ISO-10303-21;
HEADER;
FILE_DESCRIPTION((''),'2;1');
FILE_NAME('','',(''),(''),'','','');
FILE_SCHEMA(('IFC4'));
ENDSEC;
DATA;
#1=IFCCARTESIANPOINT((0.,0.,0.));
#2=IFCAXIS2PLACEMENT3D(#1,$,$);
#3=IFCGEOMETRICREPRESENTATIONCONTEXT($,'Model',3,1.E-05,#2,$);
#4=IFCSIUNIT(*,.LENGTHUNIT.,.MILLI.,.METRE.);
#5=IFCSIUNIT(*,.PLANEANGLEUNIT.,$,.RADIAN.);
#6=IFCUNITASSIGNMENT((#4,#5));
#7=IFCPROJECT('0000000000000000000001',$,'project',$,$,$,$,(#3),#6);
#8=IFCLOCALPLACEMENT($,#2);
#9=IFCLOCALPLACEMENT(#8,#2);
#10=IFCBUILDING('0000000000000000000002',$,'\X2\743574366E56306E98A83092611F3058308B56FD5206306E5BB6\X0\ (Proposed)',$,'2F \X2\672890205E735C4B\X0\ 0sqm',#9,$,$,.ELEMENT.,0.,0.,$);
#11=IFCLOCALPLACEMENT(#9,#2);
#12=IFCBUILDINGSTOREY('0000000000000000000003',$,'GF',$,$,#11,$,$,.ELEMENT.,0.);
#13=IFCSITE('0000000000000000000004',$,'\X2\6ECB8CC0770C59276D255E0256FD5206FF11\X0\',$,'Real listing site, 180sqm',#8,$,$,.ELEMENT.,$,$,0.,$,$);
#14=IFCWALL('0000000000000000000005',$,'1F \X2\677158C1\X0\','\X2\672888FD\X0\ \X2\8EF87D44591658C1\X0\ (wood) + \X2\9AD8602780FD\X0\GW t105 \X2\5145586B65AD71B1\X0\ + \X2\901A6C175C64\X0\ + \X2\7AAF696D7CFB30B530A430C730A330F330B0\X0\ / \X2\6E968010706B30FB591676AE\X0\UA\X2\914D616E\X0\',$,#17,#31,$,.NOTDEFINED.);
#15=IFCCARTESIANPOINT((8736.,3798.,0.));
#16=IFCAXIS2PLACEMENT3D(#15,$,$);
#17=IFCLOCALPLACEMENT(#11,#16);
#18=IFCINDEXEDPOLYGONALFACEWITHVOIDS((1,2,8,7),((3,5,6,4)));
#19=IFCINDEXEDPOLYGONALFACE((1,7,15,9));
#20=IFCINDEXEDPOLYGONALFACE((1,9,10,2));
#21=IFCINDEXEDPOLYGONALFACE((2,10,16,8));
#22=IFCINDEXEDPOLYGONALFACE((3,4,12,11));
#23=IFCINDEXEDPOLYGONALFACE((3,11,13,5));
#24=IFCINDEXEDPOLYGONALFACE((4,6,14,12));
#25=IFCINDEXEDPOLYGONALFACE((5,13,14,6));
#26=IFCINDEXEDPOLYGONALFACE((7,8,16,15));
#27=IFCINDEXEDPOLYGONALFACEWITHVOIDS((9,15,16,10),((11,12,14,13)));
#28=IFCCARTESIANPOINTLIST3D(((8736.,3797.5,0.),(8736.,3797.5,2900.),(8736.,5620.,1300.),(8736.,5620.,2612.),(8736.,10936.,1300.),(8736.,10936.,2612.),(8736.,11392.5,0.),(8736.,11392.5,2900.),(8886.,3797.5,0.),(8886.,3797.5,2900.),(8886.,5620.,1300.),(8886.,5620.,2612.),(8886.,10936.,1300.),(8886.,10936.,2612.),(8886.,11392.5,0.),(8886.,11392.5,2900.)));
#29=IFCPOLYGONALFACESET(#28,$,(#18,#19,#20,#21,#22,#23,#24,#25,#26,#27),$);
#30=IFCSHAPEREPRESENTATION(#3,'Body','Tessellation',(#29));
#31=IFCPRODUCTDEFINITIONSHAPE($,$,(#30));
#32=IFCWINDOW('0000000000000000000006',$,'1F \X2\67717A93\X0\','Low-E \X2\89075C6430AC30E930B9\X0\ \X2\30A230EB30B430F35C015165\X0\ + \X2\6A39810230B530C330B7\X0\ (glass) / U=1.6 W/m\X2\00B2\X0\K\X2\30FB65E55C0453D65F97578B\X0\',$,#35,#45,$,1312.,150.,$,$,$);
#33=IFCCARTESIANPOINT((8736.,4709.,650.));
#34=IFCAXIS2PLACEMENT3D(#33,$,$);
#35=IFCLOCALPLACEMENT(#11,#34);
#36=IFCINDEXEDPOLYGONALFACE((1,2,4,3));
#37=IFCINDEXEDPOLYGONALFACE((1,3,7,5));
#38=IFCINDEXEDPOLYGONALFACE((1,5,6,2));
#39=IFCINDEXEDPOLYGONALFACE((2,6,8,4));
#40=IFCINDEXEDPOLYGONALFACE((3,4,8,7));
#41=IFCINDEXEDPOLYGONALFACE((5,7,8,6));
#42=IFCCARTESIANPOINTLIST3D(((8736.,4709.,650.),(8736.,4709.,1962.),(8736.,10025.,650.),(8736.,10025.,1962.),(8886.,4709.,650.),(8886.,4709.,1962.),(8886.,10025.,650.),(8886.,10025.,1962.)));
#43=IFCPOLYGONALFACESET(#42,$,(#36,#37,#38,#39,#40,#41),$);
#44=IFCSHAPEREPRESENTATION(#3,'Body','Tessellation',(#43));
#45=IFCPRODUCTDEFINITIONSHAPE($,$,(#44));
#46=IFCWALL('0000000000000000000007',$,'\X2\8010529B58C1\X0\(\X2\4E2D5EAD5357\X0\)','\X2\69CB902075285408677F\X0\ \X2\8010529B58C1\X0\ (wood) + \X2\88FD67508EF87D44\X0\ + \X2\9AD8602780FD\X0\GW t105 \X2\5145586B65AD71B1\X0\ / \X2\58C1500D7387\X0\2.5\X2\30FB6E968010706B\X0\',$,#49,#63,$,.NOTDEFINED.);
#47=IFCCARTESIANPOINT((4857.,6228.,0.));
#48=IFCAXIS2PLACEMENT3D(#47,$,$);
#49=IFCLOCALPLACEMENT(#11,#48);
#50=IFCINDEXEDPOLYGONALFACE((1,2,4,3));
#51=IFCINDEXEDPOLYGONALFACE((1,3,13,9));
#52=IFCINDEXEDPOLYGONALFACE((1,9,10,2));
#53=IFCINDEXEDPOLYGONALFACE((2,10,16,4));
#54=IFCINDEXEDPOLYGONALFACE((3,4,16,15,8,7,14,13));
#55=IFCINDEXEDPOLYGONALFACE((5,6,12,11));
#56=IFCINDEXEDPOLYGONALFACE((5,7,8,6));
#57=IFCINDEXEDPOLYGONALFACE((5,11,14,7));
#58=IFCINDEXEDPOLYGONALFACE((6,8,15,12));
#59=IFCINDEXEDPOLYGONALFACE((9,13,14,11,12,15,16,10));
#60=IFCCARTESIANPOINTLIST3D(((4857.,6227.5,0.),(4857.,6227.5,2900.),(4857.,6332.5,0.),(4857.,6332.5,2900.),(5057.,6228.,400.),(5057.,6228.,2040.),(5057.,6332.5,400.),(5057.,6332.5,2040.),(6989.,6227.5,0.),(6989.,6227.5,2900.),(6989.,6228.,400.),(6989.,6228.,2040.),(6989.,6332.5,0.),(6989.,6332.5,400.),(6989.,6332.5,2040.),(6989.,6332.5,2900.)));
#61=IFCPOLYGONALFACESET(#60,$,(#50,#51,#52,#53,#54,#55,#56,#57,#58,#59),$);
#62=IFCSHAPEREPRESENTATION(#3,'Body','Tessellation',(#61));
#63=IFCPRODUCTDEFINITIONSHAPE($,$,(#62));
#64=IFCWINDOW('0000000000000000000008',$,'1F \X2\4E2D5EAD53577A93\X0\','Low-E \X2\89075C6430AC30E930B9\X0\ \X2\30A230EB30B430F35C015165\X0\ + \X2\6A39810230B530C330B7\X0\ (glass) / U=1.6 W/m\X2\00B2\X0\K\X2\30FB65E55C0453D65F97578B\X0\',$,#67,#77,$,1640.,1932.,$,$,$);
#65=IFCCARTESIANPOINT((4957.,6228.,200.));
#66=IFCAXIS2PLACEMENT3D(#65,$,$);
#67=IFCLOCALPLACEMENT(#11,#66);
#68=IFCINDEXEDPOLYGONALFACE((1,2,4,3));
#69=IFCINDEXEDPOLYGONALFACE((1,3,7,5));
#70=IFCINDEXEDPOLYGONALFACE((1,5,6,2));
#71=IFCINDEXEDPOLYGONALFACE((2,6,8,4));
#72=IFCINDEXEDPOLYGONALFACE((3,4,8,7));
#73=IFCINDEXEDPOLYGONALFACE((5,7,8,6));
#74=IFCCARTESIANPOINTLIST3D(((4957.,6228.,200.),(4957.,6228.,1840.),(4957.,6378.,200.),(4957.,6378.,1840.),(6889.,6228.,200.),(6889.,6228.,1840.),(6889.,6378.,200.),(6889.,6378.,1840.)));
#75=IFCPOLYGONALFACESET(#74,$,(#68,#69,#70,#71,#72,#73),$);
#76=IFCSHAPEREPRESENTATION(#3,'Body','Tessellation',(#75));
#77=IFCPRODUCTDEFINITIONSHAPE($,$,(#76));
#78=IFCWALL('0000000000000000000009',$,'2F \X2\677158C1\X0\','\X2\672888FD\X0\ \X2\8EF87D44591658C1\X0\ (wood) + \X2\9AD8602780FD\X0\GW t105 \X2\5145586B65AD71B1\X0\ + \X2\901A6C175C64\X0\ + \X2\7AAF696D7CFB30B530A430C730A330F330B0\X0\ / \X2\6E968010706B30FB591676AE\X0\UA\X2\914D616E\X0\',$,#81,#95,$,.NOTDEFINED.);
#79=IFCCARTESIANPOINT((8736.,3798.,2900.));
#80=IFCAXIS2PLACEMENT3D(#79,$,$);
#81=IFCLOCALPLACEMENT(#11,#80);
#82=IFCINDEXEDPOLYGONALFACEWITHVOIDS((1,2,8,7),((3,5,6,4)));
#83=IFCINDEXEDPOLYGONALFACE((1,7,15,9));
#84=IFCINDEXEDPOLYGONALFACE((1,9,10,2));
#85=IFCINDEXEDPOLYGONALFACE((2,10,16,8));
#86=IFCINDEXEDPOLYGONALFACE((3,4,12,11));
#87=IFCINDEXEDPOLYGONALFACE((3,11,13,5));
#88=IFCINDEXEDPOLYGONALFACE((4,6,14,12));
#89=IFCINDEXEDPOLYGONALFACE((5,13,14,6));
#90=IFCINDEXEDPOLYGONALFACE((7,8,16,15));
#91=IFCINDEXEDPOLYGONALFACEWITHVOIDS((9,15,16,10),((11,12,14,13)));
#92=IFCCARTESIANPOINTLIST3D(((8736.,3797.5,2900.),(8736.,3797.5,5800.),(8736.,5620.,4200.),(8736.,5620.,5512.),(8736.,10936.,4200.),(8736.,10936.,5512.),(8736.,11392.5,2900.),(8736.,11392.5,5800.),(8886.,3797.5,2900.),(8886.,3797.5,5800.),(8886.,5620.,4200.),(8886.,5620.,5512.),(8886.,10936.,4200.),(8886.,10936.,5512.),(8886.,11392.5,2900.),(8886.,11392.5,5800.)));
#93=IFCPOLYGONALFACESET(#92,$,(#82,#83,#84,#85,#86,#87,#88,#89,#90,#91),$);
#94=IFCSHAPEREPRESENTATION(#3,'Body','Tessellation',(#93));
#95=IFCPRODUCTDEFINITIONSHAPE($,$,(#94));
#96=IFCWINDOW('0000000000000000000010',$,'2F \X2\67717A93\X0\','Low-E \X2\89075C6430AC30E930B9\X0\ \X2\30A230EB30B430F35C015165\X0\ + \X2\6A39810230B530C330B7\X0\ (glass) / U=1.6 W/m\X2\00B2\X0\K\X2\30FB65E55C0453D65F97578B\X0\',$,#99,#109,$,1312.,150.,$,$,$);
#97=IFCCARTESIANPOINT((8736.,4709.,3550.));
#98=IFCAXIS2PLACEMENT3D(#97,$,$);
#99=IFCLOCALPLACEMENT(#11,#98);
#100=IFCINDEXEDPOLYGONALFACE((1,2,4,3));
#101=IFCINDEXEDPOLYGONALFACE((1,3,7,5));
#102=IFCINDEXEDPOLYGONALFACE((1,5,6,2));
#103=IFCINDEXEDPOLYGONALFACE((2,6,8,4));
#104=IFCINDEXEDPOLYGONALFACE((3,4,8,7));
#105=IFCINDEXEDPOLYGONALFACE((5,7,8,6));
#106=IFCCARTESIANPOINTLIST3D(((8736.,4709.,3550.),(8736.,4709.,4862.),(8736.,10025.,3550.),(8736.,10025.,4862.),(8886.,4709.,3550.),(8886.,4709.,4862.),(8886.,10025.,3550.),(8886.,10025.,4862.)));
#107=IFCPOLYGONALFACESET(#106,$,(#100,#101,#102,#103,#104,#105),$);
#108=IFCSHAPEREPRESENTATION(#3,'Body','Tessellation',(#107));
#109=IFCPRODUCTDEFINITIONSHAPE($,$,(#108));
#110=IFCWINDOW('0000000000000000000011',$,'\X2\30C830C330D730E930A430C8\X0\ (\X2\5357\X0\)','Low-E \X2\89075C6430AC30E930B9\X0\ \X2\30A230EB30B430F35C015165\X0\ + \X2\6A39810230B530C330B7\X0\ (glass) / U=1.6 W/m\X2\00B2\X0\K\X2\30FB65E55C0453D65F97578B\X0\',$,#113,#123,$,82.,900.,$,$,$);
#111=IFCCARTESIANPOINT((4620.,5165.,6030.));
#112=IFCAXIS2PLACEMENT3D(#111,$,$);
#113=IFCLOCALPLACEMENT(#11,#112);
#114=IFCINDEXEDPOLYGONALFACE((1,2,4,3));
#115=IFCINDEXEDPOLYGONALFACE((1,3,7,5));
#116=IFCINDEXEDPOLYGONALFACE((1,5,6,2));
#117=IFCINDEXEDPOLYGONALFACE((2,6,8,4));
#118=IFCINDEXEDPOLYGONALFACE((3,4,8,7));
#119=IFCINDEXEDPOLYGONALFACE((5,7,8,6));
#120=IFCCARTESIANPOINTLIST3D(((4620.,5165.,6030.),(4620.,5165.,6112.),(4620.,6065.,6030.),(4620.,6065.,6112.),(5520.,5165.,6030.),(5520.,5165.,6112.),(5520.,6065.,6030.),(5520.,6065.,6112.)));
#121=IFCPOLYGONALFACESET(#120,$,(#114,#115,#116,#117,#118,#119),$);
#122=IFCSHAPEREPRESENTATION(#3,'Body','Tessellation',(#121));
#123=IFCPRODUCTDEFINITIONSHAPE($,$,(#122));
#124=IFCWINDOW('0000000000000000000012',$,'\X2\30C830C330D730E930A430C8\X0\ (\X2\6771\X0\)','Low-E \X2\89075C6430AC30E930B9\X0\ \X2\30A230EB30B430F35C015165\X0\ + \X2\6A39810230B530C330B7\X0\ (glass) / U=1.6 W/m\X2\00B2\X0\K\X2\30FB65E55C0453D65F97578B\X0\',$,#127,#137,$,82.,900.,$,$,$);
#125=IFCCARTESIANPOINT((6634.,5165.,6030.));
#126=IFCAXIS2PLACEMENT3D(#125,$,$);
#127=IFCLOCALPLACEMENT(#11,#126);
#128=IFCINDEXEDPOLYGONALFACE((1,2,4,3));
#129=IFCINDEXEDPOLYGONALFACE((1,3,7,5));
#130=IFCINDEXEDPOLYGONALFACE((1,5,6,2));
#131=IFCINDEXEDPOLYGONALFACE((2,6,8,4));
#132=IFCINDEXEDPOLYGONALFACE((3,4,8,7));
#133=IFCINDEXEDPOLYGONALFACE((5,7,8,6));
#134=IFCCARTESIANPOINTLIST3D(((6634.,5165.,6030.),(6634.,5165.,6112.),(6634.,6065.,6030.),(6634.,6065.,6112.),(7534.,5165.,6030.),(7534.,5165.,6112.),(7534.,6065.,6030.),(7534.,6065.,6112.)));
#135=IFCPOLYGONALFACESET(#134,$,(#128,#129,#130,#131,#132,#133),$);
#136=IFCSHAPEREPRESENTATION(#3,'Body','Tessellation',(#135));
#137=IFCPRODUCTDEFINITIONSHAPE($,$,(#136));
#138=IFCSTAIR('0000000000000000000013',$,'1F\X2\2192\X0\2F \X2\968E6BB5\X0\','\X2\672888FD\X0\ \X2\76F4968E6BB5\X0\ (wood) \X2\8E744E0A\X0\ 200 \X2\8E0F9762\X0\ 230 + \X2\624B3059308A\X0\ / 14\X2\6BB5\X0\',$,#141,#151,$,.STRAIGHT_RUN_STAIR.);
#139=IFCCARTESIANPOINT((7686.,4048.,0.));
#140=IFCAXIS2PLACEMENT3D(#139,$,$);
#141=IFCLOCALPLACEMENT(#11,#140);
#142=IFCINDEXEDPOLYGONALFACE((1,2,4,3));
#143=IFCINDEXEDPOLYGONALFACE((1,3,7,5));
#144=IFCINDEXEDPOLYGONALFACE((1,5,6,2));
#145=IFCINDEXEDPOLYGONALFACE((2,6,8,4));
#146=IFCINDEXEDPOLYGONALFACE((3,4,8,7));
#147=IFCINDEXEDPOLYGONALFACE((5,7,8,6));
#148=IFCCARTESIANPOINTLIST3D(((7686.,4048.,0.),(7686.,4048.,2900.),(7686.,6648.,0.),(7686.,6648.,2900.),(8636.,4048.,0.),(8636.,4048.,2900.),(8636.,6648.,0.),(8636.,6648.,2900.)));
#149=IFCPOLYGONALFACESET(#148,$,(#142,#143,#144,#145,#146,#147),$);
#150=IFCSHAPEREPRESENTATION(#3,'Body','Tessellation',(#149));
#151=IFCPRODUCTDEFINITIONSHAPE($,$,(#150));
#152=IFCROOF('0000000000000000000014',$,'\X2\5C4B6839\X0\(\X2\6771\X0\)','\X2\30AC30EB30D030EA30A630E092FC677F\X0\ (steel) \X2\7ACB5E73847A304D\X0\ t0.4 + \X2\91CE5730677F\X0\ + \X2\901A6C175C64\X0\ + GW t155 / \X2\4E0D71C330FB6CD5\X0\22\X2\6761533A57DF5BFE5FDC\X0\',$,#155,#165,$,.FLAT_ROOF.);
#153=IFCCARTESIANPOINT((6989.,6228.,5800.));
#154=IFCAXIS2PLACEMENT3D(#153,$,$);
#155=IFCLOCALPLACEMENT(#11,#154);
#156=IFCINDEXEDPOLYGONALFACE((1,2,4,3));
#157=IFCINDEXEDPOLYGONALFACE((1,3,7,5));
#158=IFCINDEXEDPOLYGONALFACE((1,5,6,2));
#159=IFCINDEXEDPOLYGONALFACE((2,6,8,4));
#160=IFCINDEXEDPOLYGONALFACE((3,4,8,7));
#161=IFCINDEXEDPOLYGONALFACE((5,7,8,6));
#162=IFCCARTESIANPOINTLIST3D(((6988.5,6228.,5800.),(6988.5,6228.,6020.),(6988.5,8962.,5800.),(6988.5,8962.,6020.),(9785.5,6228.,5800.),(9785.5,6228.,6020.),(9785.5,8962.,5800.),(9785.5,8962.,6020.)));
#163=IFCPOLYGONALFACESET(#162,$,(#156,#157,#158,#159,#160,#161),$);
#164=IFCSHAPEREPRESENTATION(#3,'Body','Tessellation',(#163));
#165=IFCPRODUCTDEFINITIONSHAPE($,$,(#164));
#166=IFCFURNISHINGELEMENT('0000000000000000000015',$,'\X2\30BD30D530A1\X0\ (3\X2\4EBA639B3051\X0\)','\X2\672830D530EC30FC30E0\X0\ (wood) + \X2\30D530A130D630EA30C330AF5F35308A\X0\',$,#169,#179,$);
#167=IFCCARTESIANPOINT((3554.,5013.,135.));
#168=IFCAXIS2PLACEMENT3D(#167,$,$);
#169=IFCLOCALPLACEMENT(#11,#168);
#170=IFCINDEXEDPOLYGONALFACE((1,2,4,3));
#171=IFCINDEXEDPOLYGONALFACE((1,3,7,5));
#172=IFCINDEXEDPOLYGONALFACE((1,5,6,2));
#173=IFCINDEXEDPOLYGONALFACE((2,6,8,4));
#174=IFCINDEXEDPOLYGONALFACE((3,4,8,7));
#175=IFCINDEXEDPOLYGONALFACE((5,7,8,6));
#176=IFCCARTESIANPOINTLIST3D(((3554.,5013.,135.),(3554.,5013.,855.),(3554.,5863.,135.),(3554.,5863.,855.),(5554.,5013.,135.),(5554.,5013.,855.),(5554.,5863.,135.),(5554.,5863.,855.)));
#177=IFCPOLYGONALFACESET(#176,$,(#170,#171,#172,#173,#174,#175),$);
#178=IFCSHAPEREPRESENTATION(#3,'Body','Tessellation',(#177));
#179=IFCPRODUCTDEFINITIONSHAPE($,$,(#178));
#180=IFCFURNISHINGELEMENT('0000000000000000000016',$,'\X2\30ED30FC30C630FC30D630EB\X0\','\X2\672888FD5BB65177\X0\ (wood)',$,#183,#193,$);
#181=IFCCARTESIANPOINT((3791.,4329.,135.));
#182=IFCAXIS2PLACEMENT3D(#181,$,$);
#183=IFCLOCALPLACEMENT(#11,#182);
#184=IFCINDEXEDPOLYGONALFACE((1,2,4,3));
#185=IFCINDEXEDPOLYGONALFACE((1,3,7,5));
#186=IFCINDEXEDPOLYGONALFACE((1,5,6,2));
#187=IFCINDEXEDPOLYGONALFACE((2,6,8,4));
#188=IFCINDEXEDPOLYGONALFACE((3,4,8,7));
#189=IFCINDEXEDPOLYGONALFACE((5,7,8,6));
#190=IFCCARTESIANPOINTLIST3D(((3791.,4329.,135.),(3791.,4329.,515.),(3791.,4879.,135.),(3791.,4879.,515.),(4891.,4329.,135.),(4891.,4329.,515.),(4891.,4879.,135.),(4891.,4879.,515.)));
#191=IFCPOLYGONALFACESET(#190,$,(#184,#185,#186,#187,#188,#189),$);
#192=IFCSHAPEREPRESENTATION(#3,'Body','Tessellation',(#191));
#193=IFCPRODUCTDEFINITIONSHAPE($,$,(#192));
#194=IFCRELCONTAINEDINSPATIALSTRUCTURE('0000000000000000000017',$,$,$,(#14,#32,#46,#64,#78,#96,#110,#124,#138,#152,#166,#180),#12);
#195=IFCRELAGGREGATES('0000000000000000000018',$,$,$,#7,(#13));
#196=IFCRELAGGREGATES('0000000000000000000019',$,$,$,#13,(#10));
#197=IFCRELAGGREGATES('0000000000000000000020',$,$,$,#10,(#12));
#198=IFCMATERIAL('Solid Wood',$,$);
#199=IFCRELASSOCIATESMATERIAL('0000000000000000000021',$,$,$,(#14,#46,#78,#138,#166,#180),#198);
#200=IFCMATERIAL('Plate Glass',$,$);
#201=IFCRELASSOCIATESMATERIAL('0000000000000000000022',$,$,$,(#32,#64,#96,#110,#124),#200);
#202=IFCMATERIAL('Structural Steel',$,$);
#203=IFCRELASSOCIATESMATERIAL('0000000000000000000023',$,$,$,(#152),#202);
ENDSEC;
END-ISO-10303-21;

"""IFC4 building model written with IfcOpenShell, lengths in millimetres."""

from ifc_helpers import new_model, si_unit, frame, frame_2d, origin, place, context, project, spatial, rectangle, extrude, material, element, fill, save


model = new_model("IFC4")

# Units and contexts
model_context = context("Model", 3, precision=1e-05, world=origin())
ifc_project = project(units=[si_unit("LENGTHUNIT", "METRE", prefix="MILLI"), si_unit("PLANEANGLEUNIT", "RADIAN")], contexts=[model_context])

# Site, building, storey
site_placement = place(None, origin())
site = spatial("IfcSite", under=ifc_project, at=site_placement, Name="滋賀県大津市国分１", ObjectType="Real listing site, 180sqm", CompositionType="ELEMENT", RefElevation=0.0)
building_placement = place(site_placement, origin())
building = spatial("IfcBuilding", under=site, at=building_placement, Name="琵琶湖の風を感じる国分の家 (Proposed)", ObjectType="2F 木造平屋 0sqm", CompositionType="ELEMENT", ElevationOfRefHeight=0.0, ElevationOfTerrain=0.0)
storey_placement = place(building_placement, origin())
storey = spatial("IfcBuildingStorey", under=building, at=storey_placement, Name="GF", CompositionType="ELEMENT", Elevation=0.0)

# Shared definitions
ifc_material_1 = material(Name="Solid Wood")

# Walls, openings, windows
wall_1_placement = place(storey_placement, frame((8736.0, 3798.0, 0.0)))
wall_1 = element("IfcWall", 1, at=wall_1_placement, inside=storey, material=ifc_material_1, Name="1F 東壁", Description="木製 軸組外壁 (wood) + 高性能GW t105 充填断熱 + 通気層 + 窯業系サイディング / 準耐火・外皮UA配慮", PredefinedType="NOTDEFINED", context=model_context, shape_type="SweptSolid", body=[
    extrude(rectangle(XDim=150.0, YDim=7595.0, at=frame_2d((75.0, 3797.0))), frame((8736.0, 3798.0, 0.0)), (0.0, 0.0, 1.0), 2900.0),
])
opening_1_placement = place(storey_placement, frame((8736.0, 4709.0, 650.0)))
opening_1 = element("IfcOpeningElement", 2, at=opening_1_placement, cuts=wall_1, PredefinedType="NOTDEFINED", context=model_context, shape_type="SweptSolid", body=[
    extrude(rectangle(XDim=150.0, YDim=5316.0, at=frame_2d((75.0, 2658.0))), frame((8736.0, 4709.0, 650.0)), (0.0, 0.0, 1.0), 1312.0),
])
ifc_material_2 = material(Name="Plate Glass")
window_1_placement = place(storey_placement, frame((8736.0, 4709.0, 650.0)))
window_1 = element("IfcWindow", 3, at=window_1_placement, inside=storey, material=ifc_material_2, Name="1F 東窓", Description="Low-E 複層ガラス アルゴン封入 + 樹脂サッシ (glass) / U=1.6 W/m²K・日射取得型", OverallHeight=1312.0, OverallWidth=150.0, context=model_context, shape_type="SweptSolid", body=[
    extrude(rectangle(XDim=150.0, YDim=5316.0, at=frame_2d((75.0, 2658.0))), frame((8736.0, 4709.0, 650.0)), (0.0, 0.0, 1.0), 1312.0),
])
fill(opening_1, window_1)
wall_2_placement = place(storey_placement, frame((4857.0, 6228.0, 0.0)))
wall_2 = element("IfcWall", 4, at=wall_2_placement, inside=storey, material=ifc_material_1, Name="耐力壁(中庭南)", Description="構造用合板 耐力壁 (wood) + 製材軸組 + 高性能GW t105 充填断熱 / 壁倍率2.5・準耐火", PredefinedType="NOTDEFINED", context=model_context, shape_type="SweptSolid", body=[
    extrude(rectangle(XDim=2132.0, YDim=105.0, at=frame_2d((1066.0, 52.0))), frame((4857.0, 6228.0, 0.0)), (0.0, 0.0, 1.0), 2900.0),
])
opening_2_placement = place(storey_placement, frame((4957.0, 6228.0, 200.0)))
opening_2 = element("IfcOpeningElement", 5, at=opening_2_placement, cuts=wall_2, PredefinedType="NOTDEFINED", context=model_context, shape_type="SweptSolid", body=[
    extrude(rectangle(XDim=1932.0, YDim=150.0, at=frame_2d((966.0, 75.0))), frame((4957.0, 6228.0, 200.0)), (0.0, 0.0, 1.0), 1640.0),
])
window_2_placement = place(storey_placement, frame((4957.0, 6228.0, 200.0)))
window_2 = element("IfcWindow", 6, at=window_2_placement, inside=storey, material=ifc_material_2, Name="1F 中庭南窓", Description="Low-E 複層ガラス アルゴン封入 + 樹脂サッシ (glass) / U=1.6 W/m²K・日射取得型", OverallHeight=1640.0, OverallWidth=1932.0, context=model_context, shape_type="SweptSolid", body=[
    extrude(rectangle(XDim=1932.0, YDim=150.0, at=frame_2d((966.0, 75.0))), frame((4957.0, 6228.0, 200.0)), (0.0, 0.0, 1.0), 1640.0),
])
fill(opening_2, window_2)

# Wall, opening, window
wall_3_placement = place(storey_placement, frame((8736.0, 3798.0, 2900.0)))
wall_3 = element("IfcWall", 7, at=wall_3_placement, inside=storey, material=ifc_material_1, Name="2F 東壁", Description="木製 軸組外壁 (wood) + 高性能GW t105 充填断熱 + 通気層 + 窯業系サイディング / 準耐火・外皮UA配慮", PredefinedType="NOTDEFINED", context=model_context, shape_type="SweptSolid", body=[
    extrude(rectangle(XDim=150.0, YDim=7595.0, at=frame_2d((75.0, 3797.0))), frame((8736.0, 3798.0, 2900.0)), (0.0, 0.0, 1.0), 2900.0),
])
opening_3_placement = place(storey_placement, frame((8736.0, 4709.0, 3550.0)))
opening_3 = element("IfcOpeningElement", 8, at=opening_3_placement, cuts=wall_3, PredefinedType="NOTDEFINED", context=model_context, shape_type="SweptSolid", body=[
    extrude(rectangle(XDim=150.0, YDim=5316.0, at=frame_2d((75.0, 2658.0))), frame((8736.0, 4709.0, 3550.0)), (0.0, 0.0, 1.0), 1312.0),
])
window_3_placement = place(storey_placement, frame((8736.0, 4709.0, 3550.0)))
window_3 = element("IfcWindow", 9, at=window_3_placement, inside=storey, material=ifc_material_2, Name="2F 東窓", Description="Low-E 複層ガラス アルゴン封入 + 樹脂サッシ (glass) / U=1.6 W/m²K・日射取得型", OverallHeight=1312.0, OverallWidth=150.0, context=model_context, shape_type="SweptSolid", body=[
    extrude(rectangle(XDim=150.0, YDim=5316.0, at=frame_2d((75.0, 2658.0))), frame((8736.0, 4709.0, 3550.0)), (0.0, 0.0, 1.0), 1312.0),
])
fill(opening_3, window_3)

# Windows
window_4_placement = place(storey_placement, frame((4620.0, 5165.0, 6030.0)))
element("IfcWindow", 10, at=window_4_placement, inside=storey, material=ifc_material_2, Name="トップライト (南)", Description="Low-E 複層ガラス アルゴン封入 + 樹脂サッシ (glass) / U=1.6 W/m²K・日射取得型", OverallHeight=82.0, OverallWidth=900.0, context=model_context, shape_type="SweptSolid", body=[
    extrude(rectangle(XDim=900.0, YDim=900.0, at=frame_2d((450.0, 450.0))), frame((4620.0, 5165.0, 6030.0)), (0.0, 0.0, 1.0), 82.0),
])
window_5_placement = place(storey_placement, frame((6634.0, 5165.0, 6030.0)))
element("IfcWindow", 11, at=window_5_placement, inside=storey, material=ifc_material_2, Name="トップライト (東)", Description="Low-E 複層ガラス アルゴン封入 + 樹脂サッシ (glass) / U=1.6 W/m²K・日射取得型", OverallHeight=82.0, OverallWidth=900.0, context=model_context, shape_type="SweptSolid", body=[
    extrude(rectangle(XDim=900.0, YDim=900.0, at=frame_2d((450.0, 450.0))), frame((6634.0, 5165.0, 6030.0)), (0.0, 0.0, 1.0), 82.0),
])

# Stair
stair_placement = place(storey_placement, frame((7686.0, 4048.0, 0.0)))
element("IfcStair", 12, at=stair_placement, inside=storey, material=ifc_material_1, Name="1F→2F 階段", Description="木製 直階段 (wood) 蹴上 200 踏面 230 + 手すり / 14段", PredefinedType="STRAIGHT_RUN_STAIR", context=model_context, shape_type="SweptSolid", body=[
    extrude(rectangle(XDim=950.0, YDim=2600.0, at=frame_2d((475.0, 1300.0))), frame((7686.0, 4048.0, 0.0)), (0.0, 0.0, 1.0), 2900.0),
])

# Roof
ifc_material_3 = material(Name="Structural Steel")
roof_placement = place(storey_placement, frame((6989.0, 6228.0, 5800.0)))
element("IfcRoof", 13, at=roof_placement, inside=storey, material=ifc_material_3, Name="屋根(東)", Description="ガルバリウム鋼板 (steel) 立平葺き t0.4 + 野地板 + 通気層 + GW t155 / 不燃・法22条区域対応", PredefinedType="FLAT_ROOF", context=model_context, shape_type="SweptSolid", body=[
    extrude(rectangle(XDim=2797.0, YDim=2734.0, at=frame_2d((1398.0, 1367.0))), frame((6989.0, 6228.0, 5800.0)), (0.0, 0.0, 1.0), 220.0),
])

# Furnishing elements
furnishing_1_placement = place(storey_placement, frame((3554.0, 5013.0, 135.0)))
element("IfcFurnishingElement", 14, at=furnishing_1_placement, inside=storey, material=ifc_material_1, Name="ソファ (3人掛け)", Description="木フレーム (wood) + ファブリック張り", context=model_context, shape_type="SweptSolid", body=[
    extrude(rectangle(XDim=2000.0, YDim=850.0, at=frame_2d((1000.0, 425.0))), frame((3554.0, 5013.0, 135.0)), (0.0, 0.0, 1.0), 720.0),
])
furnishing_2_placement = place(storey_placement, frame((3791.0, 4329.0, 135.0)))
element("IfcFurnishingElement", 15, at=furnishing_2_placement, inside=storey, material=ifc_material_1, Name="ローテーブル", Description="木製家具 (wood)", context=model_context, shape_type="SweptSolid", body=[
    extrude(rectangle(XDim=1100.0, YDim=550.0, at=frame_2d((550.0, 275.0))), frame((3791.0, 4329.0, 135.0)), (0.0, 0.0, 1.0), 380.0),
])

save(model, "model.ifc")
